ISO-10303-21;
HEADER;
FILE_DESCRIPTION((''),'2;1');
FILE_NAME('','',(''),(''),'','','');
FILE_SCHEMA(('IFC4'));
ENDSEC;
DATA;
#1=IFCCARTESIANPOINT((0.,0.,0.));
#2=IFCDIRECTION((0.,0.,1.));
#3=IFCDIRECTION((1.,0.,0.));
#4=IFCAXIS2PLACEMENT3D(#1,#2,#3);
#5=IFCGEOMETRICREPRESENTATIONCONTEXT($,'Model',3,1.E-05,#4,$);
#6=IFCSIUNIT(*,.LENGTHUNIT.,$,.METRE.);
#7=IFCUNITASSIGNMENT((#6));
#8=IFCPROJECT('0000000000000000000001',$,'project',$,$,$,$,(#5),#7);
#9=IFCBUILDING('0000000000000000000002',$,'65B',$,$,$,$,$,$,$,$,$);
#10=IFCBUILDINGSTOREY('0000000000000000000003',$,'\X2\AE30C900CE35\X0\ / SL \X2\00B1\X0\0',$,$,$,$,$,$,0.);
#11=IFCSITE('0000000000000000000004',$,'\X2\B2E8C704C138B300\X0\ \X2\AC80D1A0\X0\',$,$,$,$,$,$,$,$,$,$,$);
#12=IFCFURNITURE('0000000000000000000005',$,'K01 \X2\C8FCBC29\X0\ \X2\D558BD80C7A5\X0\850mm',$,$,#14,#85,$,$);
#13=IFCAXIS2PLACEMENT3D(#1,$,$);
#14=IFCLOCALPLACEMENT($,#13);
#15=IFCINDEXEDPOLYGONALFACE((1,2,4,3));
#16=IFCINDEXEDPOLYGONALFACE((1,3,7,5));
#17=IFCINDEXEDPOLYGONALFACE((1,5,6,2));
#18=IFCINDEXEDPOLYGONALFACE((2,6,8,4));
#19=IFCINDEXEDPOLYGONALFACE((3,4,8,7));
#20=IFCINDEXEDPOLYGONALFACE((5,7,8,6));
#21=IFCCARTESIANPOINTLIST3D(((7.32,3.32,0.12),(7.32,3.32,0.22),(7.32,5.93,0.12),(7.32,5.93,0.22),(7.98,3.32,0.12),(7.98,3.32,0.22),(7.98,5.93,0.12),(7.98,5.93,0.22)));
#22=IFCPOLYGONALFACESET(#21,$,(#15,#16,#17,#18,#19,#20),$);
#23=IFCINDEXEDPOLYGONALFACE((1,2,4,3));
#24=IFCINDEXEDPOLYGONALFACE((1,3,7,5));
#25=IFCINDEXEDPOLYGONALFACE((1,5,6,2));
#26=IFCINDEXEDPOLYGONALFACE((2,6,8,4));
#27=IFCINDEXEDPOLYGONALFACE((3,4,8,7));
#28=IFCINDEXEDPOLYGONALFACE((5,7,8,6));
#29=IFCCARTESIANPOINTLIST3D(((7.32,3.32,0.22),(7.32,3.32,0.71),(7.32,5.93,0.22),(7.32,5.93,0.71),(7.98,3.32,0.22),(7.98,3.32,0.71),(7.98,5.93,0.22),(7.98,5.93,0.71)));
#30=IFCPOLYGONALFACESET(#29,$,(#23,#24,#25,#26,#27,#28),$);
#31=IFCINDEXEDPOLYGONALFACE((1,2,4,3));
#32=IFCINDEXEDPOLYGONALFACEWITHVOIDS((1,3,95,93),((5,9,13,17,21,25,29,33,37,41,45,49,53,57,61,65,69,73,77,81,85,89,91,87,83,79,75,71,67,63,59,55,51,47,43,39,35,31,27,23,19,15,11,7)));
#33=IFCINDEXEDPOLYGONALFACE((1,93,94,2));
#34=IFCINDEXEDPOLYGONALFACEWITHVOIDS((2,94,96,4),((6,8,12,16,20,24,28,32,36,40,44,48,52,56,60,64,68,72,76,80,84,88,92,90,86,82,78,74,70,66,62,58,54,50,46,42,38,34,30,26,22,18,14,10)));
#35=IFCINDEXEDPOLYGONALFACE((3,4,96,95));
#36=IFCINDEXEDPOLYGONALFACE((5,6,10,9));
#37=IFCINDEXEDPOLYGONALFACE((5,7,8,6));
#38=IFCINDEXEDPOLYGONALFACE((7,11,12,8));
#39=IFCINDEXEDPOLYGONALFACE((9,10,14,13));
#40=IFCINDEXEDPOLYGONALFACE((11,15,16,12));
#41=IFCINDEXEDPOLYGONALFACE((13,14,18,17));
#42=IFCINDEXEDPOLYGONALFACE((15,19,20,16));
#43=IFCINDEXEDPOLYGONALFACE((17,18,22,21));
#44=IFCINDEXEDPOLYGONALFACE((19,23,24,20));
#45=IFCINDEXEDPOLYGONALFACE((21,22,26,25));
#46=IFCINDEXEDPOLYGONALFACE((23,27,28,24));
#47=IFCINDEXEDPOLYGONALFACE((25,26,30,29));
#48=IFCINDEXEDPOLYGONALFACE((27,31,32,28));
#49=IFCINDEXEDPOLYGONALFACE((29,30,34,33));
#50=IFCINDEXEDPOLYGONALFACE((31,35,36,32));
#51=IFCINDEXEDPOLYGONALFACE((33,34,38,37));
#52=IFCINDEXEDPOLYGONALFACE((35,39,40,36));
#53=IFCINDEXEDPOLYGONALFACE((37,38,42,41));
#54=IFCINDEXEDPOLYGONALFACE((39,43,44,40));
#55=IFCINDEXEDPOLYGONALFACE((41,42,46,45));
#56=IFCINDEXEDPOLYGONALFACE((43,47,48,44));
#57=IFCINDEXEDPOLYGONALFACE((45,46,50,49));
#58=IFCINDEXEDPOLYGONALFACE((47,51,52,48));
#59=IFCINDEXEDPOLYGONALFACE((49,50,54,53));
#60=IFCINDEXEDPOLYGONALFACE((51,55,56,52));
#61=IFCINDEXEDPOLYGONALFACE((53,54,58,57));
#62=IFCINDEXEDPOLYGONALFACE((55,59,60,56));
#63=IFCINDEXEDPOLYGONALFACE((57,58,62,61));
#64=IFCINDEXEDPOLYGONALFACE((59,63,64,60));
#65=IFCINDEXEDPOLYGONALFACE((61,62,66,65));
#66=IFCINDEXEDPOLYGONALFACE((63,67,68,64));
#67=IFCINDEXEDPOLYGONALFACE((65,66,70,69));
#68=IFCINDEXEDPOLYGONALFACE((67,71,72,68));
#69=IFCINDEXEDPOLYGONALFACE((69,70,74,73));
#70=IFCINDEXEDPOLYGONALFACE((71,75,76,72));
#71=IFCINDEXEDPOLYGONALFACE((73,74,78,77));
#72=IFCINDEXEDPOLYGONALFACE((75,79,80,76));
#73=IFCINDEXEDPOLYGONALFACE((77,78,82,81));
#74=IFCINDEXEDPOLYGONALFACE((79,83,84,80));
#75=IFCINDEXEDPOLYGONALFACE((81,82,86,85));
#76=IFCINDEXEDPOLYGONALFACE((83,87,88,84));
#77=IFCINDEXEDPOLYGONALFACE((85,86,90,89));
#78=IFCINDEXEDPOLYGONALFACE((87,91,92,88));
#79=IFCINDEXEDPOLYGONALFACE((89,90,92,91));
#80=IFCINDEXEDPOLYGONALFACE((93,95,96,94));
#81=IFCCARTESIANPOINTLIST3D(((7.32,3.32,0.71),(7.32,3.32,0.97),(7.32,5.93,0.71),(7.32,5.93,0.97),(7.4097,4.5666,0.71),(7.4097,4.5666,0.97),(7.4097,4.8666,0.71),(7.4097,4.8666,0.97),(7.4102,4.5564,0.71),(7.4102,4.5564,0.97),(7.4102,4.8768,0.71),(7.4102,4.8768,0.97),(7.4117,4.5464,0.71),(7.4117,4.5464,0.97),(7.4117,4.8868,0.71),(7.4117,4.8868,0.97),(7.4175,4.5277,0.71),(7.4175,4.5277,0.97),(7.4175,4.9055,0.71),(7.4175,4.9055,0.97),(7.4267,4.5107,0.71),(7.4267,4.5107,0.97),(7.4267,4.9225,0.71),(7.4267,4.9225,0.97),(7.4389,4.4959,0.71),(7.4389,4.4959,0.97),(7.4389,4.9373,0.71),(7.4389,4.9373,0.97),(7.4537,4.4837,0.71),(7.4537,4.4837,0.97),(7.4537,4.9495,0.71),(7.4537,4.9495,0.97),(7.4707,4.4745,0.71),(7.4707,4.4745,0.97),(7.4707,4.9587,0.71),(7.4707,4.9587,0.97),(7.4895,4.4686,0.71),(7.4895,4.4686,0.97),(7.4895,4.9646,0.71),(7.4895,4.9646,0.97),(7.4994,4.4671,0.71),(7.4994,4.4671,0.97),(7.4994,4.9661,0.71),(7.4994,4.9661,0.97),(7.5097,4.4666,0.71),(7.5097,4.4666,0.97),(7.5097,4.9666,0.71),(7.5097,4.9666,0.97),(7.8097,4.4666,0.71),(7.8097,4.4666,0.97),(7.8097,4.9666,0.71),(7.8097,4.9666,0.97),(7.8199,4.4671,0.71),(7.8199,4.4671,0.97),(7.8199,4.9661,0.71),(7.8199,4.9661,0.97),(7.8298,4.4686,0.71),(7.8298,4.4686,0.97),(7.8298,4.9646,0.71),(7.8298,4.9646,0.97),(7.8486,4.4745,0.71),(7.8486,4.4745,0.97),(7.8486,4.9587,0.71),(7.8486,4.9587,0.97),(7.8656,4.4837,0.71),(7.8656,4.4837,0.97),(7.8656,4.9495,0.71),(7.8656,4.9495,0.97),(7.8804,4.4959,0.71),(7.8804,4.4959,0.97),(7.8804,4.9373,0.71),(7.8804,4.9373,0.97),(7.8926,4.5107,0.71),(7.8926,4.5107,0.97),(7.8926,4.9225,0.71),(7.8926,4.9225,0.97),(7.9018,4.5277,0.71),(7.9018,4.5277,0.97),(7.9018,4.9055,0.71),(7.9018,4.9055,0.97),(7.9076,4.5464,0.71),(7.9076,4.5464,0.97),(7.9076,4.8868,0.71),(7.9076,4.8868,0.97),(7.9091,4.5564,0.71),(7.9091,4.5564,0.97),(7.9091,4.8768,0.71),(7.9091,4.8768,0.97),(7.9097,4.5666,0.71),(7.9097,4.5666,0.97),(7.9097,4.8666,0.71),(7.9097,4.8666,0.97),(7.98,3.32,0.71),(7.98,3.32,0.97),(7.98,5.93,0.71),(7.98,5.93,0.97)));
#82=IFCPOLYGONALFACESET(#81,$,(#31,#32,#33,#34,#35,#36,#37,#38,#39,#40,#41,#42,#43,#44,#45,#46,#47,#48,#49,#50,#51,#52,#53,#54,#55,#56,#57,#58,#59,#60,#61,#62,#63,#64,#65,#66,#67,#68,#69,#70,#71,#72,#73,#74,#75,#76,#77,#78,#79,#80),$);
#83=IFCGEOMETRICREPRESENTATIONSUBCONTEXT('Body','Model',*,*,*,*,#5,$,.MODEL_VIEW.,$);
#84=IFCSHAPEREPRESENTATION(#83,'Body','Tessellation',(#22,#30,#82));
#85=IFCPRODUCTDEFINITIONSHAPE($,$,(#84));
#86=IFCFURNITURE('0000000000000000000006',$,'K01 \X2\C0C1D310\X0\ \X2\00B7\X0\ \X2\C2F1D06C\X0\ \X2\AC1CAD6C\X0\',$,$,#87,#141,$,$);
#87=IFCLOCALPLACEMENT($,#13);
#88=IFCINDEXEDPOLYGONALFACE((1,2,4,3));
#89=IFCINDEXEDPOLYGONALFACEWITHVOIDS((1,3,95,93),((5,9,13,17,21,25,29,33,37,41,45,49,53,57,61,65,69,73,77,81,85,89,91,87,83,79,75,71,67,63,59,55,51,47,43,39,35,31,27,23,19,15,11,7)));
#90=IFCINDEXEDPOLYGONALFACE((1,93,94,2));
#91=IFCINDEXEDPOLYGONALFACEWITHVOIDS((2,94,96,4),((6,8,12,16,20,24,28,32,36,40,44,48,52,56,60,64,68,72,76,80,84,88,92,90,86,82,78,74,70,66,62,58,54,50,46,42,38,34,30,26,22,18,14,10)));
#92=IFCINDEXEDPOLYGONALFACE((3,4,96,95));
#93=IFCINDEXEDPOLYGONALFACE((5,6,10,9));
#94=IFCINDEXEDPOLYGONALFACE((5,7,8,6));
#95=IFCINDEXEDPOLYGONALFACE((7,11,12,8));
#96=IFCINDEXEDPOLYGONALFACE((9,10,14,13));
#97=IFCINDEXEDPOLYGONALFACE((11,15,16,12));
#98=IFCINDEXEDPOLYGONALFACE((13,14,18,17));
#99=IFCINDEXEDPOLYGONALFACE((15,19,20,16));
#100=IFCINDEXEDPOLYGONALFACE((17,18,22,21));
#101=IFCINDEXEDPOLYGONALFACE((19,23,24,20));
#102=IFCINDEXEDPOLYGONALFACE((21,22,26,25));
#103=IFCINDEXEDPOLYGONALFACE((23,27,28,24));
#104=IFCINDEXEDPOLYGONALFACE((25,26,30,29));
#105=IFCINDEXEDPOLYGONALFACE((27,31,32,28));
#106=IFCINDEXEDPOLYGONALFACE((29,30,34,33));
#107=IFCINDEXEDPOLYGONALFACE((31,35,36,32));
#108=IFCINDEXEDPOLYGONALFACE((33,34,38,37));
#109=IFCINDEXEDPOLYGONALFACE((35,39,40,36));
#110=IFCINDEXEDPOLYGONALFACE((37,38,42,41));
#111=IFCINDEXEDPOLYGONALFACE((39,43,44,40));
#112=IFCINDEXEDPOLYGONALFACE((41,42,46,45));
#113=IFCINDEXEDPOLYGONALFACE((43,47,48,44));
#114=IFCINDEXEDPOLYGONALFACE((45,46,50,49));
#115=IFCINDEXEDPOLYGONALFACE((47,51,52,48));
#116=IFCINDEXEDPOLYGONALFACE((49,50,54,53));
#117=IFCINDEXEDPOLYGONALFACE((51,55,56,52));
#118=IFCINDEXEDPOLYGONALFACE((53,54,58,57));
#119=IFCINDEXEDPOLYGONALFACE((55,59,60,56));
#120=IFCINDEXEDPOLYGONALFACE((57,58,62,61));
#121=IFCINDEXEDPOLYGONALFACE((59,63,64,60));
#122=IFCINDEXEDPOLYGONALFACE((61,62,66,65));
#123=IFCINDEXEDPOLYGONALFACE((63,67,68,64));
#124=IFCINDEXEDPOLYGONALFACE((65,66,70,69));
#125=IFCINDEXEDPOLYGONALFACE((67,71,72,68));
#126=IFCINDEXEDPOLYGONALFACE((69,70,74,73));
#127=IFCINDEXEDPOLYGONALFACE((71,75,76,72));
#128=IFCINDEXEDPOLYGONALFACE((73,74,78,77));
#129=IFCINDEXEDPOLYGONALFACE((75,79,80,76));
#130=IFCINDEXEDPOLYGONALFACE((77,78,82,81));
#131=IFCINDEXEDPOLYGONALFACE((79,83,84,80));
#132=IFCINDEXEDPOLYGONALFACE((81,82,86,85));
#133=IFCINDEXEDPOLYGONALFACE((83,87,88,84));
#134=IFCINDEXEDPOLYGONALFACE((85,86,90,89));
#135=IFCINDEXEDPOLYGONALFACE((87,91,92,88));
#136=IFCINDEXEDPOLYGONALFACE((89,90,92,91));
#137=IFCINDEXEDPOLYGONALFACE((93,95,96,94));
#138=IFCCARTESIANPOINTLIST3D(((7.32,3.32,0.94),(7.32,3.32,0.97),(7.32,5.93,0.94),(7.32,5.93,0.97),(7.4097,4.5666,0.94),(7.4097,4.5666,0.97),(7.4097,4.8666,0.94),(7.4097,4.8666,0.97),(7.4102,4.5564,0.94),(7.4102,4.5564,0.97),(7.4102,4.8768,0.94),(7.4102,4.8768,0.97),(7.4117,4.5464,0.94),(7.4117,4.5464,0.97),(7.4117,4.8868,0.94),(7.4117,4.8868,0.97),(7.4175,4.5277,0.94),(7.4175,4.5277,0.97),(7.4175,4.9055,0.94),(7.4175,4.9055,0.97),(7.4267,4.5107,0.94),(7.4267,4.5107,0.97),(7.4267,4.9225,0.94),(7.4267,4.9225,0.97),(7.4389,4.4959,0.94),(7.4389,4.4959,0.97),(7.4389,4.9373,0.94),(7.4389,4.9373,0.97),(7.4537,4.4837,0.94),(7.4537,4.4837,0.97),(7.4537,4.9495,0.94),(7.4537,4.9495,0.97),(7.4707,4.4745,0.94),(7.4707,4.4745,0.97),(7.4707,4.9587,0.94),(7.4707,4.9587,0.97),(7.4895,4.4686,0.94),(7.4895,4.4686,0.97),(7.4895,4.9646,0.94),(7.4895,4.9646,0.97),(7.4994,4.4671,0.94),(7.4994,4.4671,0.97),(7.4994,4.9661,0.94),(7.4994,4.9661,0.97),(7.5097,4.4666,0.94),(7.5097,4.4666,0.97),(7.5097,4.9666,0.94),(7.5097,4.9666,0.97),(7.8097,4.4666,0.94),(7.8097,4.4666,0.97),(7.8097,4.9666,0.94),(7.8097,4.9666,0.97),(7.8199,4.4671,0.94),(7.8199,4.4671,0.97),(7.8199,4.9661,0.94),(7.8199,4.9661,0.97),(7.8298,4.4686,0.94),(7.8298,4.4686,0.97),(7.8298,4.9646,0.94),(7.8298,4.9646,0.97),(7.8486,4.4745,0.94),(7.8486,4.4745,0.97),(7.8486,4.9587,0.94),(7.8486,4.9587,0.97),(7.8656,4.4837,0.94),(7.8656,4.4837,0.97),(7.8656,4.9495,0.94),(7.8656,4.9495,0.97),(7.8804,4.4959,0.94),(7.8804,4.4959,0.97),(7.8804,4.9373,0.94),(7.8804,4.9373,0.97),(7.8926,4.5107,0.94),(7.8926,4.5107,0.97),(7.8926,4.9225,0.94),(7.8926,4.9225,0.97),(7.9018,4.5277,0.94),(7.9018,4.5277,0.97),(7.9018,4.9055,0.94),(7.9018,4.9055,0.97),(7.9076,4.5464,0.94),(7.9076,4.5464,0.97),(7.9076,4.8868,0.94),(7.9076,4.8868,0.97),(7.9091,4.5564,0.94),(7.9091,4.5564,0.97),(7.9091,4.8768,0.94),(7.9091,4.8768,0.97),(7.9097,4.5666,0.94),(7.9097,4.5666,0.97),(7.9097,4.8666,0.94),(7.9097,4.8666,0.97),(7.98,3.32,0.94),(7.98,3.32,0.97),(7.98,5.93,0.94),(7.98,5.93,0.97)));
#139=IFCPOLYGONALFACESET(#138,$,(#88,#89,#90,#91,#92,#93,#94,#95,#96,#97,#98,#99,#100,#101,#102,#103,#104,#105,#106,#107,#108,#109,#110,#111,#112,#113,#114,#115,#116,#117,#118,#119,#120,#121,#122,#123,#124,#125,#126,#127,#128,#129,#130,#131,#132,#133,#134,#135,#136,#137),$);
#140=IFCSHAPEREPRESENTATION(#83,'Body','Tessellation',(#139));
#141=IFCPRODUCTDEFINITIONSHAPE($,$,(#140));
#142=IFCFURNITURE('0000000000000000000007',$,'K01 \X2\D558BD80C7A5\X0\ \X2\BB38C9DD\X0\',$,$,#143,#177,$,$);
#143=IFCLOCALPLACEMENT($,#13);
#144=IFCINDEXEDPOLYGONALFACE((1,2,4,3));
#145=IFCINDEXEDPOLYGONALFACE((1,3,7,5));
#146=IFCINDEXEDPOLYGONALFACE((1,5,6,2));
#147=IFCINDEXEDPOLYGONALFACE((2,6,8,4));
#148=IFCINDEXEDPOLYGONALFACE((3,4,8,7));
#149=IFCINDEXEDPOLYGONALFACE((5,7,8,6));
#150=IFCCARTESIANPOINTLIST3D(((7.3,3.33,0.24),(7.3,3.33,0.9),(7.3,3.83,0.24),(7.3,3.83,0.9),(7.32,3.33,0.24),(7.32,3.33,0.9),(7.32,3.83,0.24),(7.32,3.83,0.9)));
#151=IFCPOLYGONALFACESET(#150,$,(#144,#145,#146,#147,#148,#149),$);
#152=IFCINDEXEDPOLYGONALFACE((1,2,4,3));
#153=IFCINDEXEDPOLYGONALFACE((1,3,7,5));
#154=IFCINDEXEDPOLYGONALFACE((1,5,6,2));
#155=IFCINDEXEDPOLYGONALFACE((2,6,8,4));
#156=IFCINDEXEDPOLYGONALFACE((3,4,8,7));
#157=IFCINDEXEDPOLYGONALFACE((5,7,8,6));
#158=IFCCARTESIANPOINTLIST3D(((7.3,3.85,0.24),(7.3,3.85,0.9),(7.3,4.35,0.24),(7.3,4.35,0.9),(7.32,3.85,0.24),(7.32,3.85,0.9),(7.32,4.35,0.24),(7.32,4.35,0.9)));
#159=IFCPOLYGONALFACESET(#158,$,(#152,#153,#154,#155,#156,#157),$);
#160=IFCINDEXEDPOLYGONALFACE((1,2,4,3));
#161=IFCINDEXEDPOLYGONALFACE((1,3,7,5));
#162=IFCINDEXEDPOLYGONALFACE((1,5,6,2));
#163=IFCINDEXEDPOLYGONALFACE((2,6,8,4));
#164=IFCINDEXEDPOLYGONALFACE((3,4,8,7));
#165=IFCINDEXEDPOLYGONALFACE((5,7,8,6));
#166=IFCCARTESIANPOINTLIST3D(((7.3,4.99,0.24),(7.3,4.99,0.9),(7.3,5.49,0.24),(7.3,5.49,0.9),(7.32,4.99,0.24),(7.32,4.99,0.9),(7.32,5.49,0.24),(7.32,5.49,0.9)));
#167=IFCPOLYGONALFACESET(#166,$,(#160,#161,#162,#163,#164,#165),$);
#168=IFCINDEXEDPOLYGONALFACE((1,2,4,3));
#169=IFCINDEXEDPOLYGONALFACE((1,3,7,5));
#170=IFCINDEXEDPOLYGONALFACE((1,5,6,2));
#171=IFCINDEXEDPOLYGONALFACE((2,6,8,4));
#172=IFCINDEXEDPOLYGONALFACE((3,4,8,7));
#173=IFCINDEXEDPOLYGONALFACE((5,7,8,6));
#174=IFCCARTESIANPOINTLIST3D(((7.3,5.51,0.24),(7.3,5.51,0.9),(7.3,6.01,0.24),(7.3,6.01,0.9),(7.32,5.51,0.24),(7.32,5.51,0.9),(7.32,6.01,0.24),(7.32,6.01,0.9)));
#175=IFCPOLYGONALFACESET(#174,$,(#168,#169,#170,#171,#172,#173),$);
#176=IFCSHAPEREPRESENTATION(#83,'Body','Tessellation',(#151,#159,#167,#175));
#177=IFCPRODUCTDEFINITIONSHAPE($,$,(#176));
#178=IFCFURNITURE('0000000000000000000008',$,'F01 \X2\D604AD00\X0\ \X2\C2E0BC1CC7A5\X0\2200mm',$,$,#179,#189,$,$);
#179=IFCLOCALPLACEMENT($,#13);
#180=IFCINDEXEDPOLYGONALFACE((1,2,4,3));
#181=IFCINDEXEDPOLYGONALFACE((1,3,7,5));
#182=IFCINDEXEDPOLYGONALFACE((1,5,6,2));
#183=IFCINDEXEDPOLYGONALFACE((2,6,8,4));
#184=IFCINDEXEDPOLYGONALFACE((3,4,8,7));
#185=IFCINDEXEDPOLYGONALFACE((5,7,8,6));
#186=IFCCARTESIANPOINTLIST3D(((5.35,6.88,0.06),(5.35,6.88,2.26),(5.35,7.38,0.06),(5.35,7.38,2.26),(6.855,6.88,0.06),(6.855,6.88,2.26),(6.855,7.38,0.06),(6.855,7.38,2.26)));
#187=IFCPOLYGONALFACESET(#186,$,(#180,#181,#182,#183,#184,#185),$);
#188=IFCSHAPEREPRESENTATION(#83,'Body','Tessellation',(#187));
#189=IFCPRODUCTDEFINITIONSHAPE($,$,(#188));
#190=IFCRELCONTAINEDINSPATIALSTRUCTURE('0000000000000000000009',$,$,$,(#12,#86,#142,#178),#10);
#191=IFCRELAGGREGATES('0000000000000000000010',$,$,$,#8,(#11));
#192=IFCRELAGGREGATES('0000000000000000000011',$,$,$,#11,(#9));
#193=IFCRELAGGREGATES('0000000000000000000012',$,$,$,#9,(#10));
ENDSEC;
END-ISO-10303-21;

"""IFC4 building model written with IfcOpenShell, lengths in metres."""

from ifc_helpers import new_model, si_unit, frame, origin_with_axes, place, context, subcontext, project, spatial, polyline, outline, extrude, element, save


model = new_model("IFC4")

# Units and contexts
model_context = context("Model", 3, precision=1e-05, world=origin_with_axes())
body_context = subcontext(model_context, "Body", "Model", "MODEL_VIEW")
ifc_project = project(units=[si_unit("LENGTHUNIT", "METRE")], contexts=[model_context])

# Site, building, storey
site = spatial("IfcSite", under=ifc_project, Name="단위세대 검토")
building = spatial("IfcBuilding", under=site, Name="65B")
storey = spatial("IfcBuildingStorey", under=building, Name="기준층 / SL ±0", Elevation=0.0)

# Furniture
furniture_1_placement = place(None, origin_with_axes())
element("IfcFurniture", 1, at=furniture_1_placement, inside=storey, Name="K01 주방 하부장850mm", context=body_context, shape_type="SweptSolid", body=[
    extrude(outline(polyline([(7.98, 3.32), (7.98, 5.93), (7.32, 5.93), (7.32, 3.32), (7.98, 3.32)])), frame((0.0, 0.0, 0.12)), (0.0, 0.0, 1.0), 0.1),
    extrude(outline(polyline([(7.98, 3.32), (7.98, 5.93), (7.32, 5.93), (7.32, 3.32), (7.98, 3.32)])), frame((0.0, 0.0, 0.22)), (0.0, 0.0, 1.0), 0.49),
    extrude(outline(polyline([(7.32, 3.32), (7.32, 5.93), (7.98, 5.93), (7.98, 3.32), (7.32, 3.32)]), holes=[polyline([(7.4102, 4.5564), (7.4117, 4.5464), (7.4175, 4.5277), (7.4267, 4.5107), (7.4389, 4.4959), (7.4537, 4.4837), (7.4707, 4.4745), (7.4895, 4.4686), (7.4994, 4.4671), (7.5097, 4.4666), (7.8097, 4.4666), (7.8199, 4.4671), (7.8298, 4.4686), (7.8486, 4.4745), (7.8656, 4.4837), (7.8804, 4.4959), (7.8926, 4.5107), (7.9018, 4.5277), (7.9076, 4.5464), (7.9091, 4.5564), (7.9097, 4.5666), (7.9097, 4.8666), (7.9091, 4.8768), (7.9076, 4.8868), (7.9018, 4.9055), (7.8926, 4.9225), (7.8804, 4.9373), (7.8656, 4.9495), (7.8486, 4.9587), (7.8298, 4.9646), (7.8199, 4.9661), (7.8097, 4.9666), (7.5097, 4.9666), (7.4994, 4.9661), (7.4895, 4.9646), (7.4707, 4.9587), (7.4537, 4.9495), (7.4389, 4.9373), (7.4267, 4.9225), (7.4175, 4.9055), (7.4117, 4.8868), (7.4102, 4.8768), (7.4097, 4.8666), (7.4097, 4.5666), (7.4102, 4.5564)])]), frame((0.0, 0.0, 0.71)), (0.0, 0.0, 1.0), 0.26),
])
furniture_2_placement = place(None, origin_with_axes())
element("IfcFurniture", 2, at=furniture_2_placement, inside=storey, Name="K01 상판 · 싱크 개구", context=body_context, shape_type="SweptSolid", body=[
    extrude(outline(polyline([(7.32, 3.32), (7.32, 5.93), (7.98, 5.93), (7.98, 3.32), (7.32, 3.32)]), holes=[polyline([(7.4102, 4.5564), (7.4117, 4.5464), (7.4175, 4.5277), (7.4267, 4.5107), (7.4389, 4.4959), (7.4537, 4.4837), (7.4707, 4.4745), (7.4895, 4.4686), (7.4994, 4.4671), (7.5097, 4.4666), (7.8097, 4.4666), (7.8199, 4.4671), (7.8298, 4.4686), (7.8486, 4.4745), (7.8656, 4.4837), (7.8804, 4.4959), (7.8926, 4.5107), (7.9018, 4.5277), (7.9076, 4.5464), (7.9091, 4.5564), (7.9097, 4.5666), (7.9097, 4.8666), (7.9091, 4.8768), (7.9076, 4.8868), (7.9018, 4.9055), (7.8926, 4.9225), (7.8804, 4.9373), (7.8656, 4.9495), (7.8486, 4.9587), (7.8298, 4.9646), (7.8199, 4.9661), (7.8097, 4.9666), (7.5097, 4.9666), (7.4994, 4.9661), (7.4895, 4.9646), (7.4707, 4.9587), (7.4537, 4.9495), (7.4389, 4.9373), (7.4267, 4.9225), (7.4175, 4.9055), (7.4117, 4.8868), (7.4102, 4.8768), (7.4097, 4.8666), (7.4097, 4.5666), (7.4102, 4.5564)])]), frame((0.0, 0.0, 0.94)), (0.0, 0.0, 1.0), 0.03),
])
furniture_3_placement = place(None, origin_with_axes())
element("IfcFurniture", 3, at=furniture_3_placement, inside=storey, Name="K01 하부장 문짝", context=body_context, shape_type="SweptSolid", body=[
    extrude(outline(polyline([(7.32, 3.33), (7.32, 3.83), (7.3, 3.83), (7.3, 3.33), (7.32, 3.33)])), frame((0.0, 0.0, 0.24)), (0.0, 0.0, 1.0), 0.66),
    extrude(outline(polyline([(7.32, 3.85), (7.32, 4.35), (7.3, 4.35), (7.3, 3.85), (7.32, 3.85)])), frame((0.0, 0.0, 0.24)), (0.0, 0.0, 1.0), 0.66),
    extrude(outline(polyline([(7.32, 4.99), (7.32, 5.49), (7.3, 5.49), (7.3, 4.99), (7.32, 4.99)])), frame((0.0, 0.0, 0.24)), (0.0, 0.0, 1.0), 0.66),
    extrude(outline(polyline([(7.32, 5.51), (7.32, 6.01), (7.3, 6.01), (7.3, 5.51), (7.32, 5.51)])), frame((0.0, 0.0, 0.24)), (0.0, 0.0, 1.0), 0.66),
])
furniture_4_placement = place(None, origin_with_axes())
element("IfcFurniture", 4, at=furniture_4_placement, inside=storey, Name="F01 현관 신발장2200mm", context=body_context, shape_type="SweptSolid", body=[
    extrude(outline(polyline([(6.855, 6.88), (6.855, 7.38), (5.35, 7.38), (5.35, 6.88), (6.855, 6.88)])), frame((0.0, 0.0, 0.06)), (0.0, 0.0, 1.0), 2.2),
])

save(model, "model.ifc")
